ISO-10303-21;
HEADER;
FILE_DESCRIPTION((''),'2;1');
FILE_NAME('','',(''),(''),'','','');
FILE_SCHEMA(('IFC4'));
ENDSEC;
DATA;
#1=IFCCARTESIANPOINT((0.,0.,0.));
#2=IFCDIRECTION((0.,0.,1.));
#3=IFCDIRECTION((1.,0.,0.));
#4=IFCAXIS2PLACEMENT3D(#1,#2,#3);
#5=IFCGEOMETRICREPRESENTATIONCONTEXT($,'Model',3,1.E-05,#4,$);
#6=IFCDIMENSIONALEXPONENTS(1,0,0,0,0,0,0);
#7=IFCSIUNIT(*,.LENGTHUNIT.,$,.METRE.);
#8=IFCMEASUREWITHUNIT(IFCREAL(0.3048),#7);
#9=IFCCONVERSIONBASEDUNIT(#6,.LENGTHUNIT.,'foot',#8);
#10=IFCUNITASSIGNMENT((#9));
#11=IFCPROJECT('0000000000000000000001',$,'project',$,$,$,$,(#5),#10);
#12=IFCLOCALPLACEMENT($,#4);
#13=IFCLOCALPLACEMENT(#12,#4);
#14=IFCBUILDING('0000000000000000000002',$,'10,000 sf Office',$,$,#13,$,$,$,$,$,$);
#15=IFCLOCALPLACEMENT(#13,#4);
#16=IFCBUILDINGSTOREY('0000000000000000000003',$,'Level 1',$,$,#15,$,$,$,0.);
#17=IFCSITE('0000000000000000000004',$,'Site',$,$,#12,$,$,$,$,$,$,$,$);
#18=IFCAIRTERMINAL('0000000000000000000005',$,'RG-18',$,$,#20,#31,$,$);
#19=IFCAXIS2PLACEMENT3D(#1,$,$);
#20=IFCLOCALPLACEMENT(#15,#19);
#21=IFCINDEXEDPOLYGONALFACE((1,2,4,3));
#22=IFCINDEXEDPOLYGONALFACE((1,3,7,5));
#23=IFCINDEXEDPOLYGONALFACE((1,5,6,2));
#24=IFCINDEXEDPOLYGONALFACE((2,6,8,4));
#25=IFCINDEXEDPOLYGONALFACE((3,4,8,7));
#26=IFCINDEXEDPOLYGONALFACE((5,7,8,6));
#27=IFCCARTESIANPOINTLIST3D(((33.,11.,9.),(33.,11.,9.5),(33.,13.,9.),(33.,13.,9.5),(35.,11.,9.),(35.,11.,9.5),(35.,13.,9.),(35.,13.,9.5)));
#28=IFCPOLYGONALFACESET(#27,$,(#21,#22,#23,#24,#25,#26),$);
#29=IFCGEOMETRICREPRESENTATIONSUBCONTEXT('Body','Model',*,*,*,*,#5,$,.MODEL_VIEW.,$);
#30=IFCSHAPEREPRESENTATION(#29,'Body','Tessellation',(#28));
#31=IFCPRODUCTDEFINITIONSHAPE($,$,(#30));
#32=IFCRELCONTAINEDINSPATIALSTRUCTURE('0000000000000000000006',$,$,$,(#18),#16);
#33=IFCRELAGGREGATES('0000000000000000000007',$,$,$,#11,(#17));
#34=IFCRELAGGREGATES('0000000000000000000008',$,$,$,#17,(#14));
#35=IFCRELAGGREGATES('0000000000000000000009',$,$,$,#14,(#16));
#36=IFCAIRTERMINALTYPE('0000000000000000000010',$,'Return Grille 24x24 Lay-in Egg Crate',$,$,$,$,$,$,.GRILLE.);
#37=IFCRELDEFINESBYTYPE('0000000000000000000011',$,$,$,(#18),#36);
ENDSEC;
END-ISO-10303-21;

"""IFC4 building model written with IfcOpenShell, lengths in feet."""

from ifc_helpers import new_model, entity, si_unit, converted_unit, frame, origin_with_axes, place, context, subcontext, project, spatial, rectangle, extrude, type_object, element, save


model = new_model("IFC4")

# Units and contexts
model_context = context("Model", 3, precision=1e-05, world=origin_with_axes())
body_context = subcontext(model_context, "Body", "Model", "MODEL_VIEW")
ifc_project = project(units=[converted_unit("LENGTHUNIT", "foot", entity("IfcReal", 0.3048), si_unit("LENGTHUNIT", "METRE"), dimensions=[1, 0, 0, 0, 0, 0, 0])], contexts=[model_context])

# Site, building, storey
site_placement = place(None, origin_with_axes())
site = spatial("IfcSite", under=ifc_project, at=site_placement, Name="Site")
building_placement = place(site_placement, origin_with_axes())
building = spatial("IfcBuilding", under=site, at=building_placement, Name="10,000 sf Office")
storey_placement = place(building_placement, origin_with_axes())
storey = spatial("IfcBuildingStorey", under=building, at=storey_placement, Name="Level 1", Elevation=0.0)

# Air terminal
air_terminal_type_1 = type_object("IfcAirTerminalType", Name="Return Grille 24x24 Lay-in Egg Crate", PredefinedType="GRILLE")
for number, where, z_axis, x_axis, name in (
    (1, (34.0, 12.0, 9.0), (0.0, 0.0, 1.0), (1.0, 0.0, 0.0), "RG-18"),
):
    element("IfcAirTerminal", number, at=place(storey_placement, frame(where, z_axis=z_axis, x_axis=x_axis)), inside=storey, type_object=air_terminal_type_1, Name=name, context=body_context, shape_type="SweptSolid", body=[
        extrude(rectangle(XDim=2.0, YDim=2.0), None, (0.0, 0.0, 1.0), 0.5),
    ])

save(model, "model.ifc")
